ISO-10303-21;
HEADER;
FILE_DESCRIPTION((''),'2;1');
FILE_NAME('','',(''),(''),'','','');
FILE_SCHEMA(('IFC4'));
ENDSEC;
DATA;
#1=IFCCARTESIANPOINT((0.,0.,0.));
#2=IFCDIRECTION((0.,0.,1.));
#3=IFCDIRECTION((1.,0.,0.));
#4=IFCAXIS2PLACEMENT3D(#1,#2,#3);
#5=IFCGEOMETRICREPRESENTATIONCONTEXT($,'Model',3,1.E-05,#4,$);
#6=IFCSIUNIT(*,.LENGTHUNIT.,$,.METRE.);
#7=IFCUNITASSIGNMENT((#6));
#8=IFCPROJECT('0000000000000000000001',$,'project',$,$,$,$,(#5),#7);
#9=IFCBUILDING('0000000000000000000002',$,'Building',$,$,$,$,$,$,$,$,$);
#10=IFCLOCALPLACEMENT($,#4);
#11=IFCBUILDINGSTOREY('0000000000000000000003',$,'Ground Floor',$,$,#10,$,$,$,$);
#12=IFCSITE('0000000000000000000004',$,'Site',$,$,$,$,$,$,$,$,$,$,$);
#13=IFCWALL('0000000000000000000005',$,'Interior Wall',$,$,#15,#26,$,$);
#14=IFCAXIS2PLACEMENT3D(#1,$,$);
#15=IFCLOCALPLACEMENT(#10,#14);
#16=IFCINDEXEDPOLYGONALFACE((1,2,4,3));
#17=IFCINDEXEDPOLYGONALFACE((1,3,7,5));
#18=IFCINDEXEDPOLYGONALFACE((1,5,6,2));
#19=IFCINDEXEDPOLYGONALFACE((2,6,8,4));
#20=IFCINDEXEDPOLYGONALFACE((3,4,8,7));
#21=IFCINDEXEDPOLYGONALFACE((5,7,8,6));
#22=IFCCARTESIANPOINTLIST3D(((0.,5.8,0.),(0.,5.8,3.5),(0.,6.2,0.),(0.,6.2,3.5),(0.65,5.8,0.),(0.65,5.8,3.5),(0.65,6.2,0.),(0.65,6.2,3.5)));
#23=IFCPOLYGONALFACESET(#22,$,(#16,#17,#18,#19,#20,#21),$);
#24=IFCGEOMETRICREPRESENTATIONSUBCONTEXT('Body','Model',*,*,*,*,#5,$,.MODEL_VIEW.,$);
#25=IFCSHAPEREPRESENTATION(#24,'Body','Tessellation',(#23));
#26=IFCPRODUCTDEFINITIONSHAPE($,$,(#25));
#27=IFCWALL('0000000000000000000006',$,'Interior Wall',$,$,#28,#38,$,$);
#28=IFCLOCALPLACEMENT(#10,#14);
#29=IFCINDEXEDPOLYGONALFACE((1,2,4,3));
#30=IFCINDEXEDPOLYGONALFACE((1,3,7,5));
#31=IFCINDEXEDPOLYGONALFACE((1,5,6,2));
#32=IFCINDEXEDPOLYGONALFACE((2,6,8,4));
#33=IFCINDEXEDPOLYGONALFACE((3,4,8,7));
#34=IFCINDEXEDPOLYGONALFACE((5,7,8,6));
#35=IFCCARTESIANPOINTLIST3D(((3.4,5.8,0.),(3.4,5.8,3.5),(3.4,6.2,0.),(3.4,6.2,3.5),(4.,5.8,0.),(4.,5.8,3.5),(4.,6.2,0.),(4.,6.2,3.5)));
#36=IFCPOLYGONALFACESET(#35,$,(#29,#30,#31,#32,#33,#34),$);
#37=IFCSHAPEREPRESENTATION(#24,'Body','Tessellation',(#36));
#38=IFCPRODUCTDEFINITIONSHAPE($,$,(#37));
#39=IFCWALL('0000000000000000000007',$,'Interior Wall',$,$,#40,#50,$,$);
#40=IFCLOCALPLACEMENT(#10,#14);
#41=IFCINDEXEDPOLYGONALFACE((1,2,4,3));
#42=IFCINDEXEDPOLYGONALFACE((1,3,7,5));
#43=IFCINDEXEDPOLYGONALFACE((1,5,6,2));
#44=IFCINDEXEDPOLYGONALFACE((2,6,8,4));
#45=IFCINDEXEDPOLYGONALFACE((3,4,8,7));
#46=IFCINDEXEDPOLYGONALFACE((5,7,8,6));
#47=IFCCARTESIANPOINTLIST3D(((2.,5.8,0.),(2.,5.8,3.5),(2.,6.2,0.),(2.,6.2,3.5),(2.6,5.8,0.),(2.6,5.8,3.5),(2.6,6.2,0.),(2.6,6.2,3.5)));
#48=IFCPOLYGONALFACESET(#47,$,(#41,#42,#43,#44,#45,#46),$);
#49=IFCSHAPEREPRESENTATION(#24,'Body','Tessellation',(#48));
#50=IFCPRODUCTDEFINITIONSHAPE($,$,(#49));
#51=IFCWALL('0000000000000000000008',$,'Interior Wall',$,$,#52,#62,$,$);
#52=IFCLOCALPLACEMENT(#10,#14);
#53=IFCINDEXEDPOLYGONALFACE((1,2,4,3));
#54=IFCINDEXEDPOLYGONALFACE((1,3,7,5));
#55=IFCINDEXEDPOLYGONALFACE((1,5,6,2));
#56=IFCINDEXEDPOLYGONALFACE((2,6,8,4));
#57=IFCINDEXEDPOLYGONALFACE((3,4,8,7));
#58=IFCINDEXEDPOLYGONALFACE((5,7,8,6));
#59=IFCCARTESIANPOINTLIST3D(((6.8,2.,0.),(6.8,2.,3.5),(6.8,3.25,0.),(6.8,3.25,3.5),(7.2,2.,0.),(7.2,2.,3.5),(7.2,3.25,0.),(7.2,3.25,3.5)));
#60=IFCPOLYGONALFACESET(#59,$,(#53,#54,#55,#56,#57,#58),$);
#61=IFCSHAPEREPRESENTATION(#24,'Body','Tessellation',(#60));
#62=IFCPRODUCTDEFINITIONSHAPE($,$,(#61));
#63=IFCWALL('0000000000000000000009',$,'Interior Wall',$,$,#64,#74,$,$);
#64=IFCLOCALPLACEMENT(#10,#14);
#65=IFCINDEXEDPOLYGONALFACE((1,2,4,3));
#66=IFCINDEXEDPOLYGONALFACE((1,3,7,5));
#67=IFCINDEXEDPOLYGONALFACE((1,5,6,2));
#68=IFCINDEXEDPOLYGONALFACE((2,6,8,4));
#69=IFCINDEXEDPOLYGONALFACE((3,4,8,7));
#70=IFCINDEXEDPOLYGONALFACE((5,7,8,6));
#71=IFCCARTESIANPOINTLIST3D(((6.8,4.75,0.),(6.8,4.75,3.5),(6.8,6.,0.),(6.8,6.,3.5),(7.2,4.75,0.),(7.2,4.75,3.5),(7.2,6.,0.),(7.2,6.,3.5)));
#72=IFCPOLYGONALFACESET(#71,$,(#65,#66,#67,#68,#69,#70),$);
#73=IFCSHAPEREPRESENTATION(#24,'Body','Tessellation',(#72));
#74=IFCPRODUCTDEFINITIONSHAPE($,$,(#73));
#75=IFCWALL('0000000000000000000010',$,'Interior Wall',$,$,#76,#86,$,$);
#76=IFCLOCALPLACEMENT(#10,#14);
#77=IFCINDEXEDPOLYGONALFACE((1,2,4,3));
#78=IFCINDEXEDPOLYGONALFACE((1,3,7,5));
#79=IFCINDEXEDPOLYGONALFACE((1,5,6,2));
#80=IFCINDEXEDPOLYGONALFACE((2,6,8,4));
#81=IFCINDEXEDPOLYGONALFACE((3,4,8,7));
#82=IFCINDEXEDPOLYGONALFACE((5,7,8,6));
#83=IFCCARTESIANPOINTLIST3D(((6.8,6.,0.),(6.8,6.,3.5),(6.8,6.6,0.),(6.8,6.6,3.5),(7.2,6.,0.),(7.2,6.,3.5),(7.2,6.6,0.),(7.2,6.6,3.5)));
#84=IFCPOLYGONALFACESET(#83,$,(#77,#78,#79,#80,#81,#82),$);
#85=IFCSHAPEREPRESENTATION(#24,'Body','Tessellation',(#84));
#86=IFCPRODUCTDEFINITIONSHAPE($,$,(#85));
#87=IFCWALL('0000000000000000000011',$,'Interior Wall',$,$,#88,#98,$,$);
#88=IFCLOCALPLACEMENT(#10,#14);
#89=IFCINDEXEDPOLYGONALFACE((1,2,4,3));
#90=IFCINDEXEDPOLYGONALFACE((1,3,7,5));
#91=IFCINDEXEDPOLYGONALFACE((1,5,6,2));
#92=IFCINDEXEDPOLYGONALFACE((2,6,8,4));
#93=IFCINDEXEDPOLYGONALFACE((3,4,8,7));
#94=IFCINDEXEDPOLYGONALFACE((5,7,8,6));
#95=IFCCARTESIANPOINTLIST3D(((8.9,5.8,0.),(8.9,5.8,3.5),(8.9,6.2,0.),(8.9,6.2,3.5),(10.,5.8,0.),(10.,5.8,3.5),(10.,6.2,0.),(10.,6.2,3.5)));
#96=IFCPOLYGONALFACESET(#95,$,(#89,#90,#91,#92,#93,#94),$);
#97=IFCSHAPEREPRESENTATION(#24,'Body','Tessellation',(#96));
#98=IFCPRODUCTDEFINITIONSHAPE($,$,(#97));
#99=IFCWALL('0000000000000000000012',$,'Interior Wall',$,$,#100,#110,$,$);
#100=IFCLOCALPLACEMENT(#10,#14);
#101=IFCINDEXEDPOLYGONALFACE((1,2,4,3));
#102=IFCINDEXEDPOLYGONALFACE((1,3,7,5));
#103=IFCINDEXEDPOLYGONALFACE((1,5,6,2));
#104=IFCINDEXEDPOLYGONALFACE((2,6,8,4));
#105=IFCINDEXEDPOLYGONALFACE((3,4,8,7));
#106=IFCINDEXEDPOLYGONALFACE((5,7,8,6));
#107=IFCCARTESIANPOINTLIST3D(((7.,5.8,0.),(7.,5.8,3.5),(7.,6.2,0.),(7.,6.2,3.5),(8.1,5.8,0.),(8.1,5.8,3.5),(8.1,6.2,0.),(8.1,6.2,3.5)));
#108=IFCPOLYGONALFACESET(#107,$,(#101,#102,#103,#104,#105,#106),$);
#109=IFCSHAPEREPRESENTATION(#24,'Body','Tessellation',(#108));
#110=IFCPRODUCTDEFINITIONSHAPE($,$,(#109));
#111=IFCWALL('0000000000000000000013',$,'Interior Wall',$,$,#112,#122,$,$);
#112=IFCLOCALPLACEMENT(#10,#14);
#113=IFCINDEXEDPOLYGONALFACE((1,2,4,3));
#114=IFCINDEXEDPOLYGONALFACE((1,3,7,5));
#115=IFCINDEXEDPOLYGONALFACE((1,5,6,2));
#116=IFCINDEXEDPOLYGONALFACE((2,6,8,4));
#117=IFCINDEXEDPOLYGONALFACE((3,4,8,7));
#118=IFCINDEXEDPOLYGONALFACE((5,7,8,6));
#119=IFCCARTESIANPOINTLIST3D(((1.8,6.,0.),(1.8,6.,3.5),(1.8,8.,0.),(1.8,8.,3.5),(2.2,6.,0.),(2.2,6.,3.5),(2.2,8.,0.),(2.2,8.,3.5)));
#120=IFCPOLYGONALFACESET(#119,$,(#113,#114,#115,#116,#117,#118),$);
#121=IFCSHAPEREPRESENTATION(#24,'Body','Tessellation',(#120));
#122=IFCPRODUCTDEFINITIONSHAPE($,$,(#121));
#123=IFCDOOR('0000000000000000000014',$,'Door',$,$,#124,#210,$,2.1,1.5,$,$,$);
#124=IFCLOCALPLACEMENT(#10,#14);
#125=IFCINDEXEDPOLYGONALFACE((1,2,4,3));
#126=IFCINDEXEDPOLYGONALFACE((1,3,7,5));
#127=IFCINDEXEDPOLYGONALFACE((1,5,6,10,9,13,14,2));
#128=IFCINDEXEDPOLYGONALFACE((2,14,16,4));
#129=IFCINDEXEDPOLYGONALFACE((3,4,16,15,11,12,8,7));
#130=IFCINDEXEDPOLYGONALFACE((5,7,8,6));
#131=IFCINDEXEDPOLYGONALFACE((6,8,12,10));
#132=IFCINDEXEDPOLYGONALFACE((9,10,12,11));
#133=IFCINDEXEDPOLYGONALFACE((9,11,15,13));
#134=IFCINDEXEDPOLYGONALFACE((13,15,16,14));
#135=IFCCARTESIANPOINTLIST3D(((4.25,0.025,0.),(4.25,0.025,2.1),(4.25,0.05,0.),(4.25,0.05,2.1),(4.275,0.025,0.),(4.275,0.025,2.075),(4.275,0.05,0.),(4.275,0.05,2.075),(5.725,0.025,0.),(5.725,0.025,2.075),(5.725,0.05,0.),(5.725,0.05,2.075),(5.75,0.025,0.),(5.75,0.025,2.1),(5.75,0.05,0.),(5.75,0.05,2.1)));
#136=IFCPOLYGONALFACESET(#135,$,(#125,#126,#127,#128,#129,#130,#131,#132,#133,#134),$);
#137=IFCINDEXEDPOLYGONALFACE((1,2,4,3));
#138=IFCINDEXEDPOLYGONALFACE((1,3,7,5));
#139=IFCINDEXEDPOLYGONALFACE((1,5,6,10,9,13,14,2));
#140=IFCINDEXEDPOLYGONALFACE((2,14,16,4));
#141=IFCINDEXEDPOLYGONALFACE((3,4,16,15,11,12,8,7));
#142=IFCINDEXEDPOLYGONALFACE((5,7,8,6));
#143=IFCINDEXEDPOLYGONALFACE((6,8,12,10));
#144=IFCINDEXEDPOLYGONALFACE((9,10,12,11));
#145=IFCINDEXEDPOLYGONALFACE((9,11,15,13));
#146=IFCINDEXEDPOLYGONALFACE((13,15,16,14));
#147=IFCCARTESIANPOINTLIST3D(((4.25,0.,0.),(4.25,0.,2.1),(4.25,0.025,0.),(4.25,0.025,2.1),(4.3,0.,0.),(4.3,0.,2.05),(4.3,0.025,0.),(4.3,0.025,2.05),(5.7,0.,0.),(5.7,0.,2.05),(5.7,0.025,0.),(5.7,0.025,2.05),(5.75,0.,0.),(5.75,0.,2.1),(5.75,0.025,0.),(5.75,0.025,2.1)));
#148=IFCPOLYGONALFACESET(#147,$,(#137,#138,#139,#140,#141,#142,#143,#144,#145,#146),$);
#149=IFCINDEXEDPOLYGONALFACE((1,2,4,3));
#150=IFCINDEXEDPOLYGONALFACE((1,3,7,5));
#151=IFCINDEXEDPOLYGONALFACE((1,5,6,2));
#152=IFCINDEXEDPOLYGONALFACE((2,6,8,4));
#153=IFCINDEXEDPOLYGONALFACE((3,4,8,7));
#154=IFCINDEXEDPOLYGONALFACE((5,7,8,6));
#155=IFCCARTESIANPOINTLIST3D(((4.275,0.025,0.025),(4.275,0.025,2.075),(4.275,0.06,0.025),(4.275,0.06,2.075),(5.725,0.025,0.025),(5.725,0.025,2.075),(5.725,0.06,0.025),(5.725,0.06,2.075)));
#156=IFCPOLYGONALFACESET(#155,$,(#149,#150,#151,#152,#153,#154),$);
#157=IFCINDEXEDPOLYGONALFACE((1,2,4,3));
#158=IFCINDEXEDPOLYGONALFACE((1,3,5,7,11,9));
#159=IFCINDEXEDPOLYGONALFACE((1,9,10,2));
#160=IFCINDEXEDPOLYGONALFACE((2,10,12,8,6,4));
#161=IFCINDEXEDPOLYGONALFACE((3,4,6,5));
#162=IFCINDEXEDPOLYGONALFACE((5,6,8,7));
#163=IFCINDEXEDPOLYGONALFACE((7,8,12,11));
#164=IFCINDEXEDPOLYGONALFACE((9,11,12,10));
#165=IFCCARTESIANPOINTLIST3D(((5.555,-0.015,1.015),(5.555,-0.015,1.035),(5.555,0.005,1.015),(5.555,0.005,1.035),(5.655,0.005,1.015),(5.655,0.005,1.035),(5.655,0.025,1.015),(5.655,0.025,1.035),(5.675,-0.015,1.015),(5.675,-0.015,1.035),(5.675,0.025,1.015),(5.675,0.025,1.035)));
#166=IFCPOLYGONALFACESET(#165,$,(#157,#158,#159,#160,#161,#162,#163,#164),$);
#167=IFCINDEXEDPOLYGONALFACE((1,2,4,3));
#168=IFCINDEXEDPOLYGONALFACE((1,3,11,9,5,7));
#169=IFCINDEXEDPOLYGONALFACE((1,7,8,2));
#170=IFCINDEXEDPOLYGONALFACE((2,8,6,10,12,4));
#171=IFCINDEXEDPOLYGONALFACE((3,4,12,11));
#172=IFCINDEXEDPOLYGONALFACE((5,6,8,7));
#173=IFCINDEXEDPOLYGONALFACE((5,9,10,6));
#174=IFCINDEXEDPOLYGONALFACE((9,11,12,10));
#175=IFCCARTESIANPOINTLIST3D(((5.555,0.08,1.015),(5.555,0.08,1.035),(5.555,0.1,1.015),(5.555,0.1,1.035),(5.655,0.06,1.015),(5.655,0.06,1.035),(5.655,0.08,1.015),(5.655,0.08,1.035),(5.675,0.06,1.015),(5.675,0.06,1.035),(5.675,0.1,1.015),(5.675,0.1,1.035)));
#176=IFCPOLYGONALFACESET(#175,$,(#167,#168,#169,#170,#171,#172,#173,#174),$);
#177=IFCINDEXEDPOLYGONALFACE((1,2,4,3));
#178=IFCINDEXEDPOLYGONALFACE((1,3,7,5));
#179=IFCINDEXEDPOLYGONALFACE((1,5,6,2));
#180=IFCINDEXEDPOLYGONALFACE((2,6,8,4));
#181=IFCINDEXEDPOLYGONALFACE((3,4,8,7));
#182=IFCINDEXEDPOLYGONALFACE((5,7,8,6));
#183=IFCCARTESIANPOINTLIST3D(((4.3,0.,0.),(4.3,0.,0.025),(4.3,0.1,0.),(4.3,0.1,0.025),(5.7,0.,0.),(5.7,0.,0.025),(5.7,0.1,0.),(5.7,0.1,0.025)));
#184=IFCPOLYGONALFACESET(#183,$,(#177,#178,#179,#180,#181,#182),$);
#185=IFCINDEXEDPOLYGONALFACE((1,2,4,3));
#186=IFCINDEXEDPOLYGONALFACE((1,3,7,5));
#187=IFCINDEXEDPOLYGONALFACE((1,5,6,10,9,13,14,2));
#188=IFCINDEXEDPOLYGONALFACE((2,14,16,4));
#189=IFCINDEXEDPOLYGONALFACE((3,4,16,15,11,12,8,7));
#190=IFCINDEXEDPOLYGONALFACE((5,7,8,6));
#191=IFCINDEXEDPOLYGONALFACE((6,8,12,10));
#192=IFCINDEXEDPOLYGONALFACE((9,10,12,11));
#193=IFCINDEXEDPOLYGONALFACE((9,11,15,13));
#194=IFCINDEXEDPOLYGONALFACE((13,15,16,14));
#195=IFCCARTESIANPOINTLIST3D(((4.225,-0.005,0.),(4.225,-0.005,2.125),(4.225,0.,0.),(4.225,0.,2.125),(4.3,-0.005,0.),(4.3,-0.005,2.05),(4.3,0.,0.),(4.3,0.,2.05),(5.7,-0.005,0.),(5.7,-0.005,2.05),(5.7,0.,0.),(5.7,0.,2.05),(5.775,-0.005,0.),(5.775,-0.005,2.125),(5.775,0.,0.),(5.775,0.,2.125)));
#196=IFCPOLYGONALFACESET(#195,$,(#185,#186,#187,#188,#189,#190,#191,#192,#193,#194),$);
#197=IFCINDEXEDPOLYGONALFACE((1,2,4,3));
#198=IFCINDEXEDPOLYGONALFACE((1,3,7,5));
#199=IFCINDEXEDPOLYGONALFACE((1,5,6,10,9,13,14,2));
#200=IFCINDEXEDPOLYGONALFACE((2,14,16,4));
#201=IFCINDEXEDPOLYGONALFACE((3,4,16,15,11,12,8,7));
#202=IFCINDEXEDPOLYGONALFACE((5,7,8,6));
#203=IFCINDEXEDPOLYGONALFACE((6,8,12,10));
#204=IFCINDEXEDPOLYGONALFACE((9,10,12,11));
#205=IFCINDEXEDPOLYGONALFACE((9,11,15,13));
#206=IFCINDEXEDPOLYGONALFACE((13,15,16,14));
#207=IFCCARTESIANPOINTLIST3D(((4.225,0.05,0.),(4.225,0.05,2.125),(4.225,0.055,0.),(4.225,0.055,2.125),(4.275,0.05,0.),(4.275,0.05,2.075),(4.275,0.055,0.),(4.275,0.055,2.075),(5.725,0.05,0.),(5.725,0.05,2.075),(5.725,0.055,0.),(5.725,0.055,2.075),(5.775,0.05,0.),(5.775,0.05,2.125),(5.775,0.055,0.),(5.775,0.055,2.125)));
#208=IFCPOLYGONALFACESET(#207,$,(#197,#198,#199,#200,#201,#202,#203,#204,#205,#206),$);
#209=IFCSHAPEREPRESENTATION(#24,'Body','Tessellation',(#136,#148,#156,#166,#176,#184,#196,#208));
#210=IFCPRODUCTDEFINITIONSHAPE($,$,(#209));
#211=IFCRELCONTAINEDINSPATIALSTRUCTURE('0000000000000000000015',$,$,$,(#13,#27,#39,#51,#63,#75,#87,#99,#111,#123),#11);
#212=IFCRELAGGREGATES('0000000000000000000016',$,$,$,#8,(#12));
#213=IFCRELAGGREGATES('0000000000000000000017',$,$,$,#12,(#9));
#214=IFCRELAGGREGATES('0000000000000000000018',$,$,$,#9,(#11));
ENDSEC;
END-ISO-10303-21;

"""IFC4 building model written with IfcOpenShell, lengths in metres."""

from ifc_helpers import new_model, si_unit, frame, origin_with_axes, place, context, subcontext, project, spatial, line, indexed_curve, outline, extrude, element, save


model = new_model("IFC4")

# Units and contexts
model_context = context("Model", 3, precision=1e-05, world=origin_with_axes())
body_context = subcontext(model_context, "Body", "Model", "MODEL_VIEW")
ifc_project = project(units=[si_unit("LENGTHUNIT", "METRE")], contexts=[model_context])

# Site, building, storey
site = spatial("IfcSite", under=ifc_project, Name="Site")
building = spatial("IfcBuilding", under=site, Name="Building")
storey_placement = place(None, origin_with_axes())
storey = spatial("IfcBuildingStorey", under=building, at=storey_placement, Name="Ground Floor")

# Walls
for number, where, z_axis, x_axis, name in (
    (1, (0.65, 6.0, 0.0), (0.0, 0.0, 1.0), (-1.0, 0.0, 0.0), "Interior Wall"),
):
    element("IfcWall", number, at=place(storey_placement, frame(where, z_axis=z_axis, x_axis=x_axis)), inside=storey, Name=name, context=body_context, shape_type="SweptSolid", body=[
        extrude(outline(indexed_curve([(0.0, 0.0), (0.0, 0.4), (0.65, 0.4), (0.65, 0.0), (0.0, 0.0)], self_intersect=False)), frame((0.0, -0.2, 0.0), z_axis=(0.0, 0.0, 1.0), x_axis=(1.0, 0.0, 0.0)), (0.0, 0.0, 1.0), 3.5),
    ])
for number, where, z_axis, x_axis, name in (
    (2, (4.0, 6.0, 0.0), (0.0, 0.0, 1.0), (-1.0, 0.0, 0.0), "Interior Wall"),
    (3, (2.6, 6.0, 0.0), (0.0, 0.0, 1.0), (-1.0, 0.0, 0.0), "Interior Wall"),
):
    element("IfcWall", number, at=place(storey_placement, frame(where, z_axis=z_axis, x_axis=x_axis)), inside=storey, Name=name, context=body_context, shape_type="SweptSolid", body=[
        extrude(outline(indexed_curve([(0.0, 0.0), (0.0, 0.4), (0.6, 0.4), (0.6, 0.0), (0.0, 0.0)], self_intersect=False)), frame((0.0, -0.2, 0.0), z_axis=(0.0, 0.0, 1.0), x_axis=(1.0, 0.0, 0.0)), (0.0, 0.0, 1.0), 3.5),
    ])
for number, where, z_axis, x_axis, name in (
    (4, (7.0, 2.0, 0.0), (0.0, 0.0, 1.0), (0.0, 1.0, 0.0), "Interior Wall"),
    (5, (7.0, 4.75, 0.0), (0.0, 0.0, 1.0), (0.0, 1.0, 0.0), "Interior Wall"),
):
    element("IfcWall", number, at=place(storey_placement, frame(where, z_axis=z_axis, x_axis=x_axis)), inside=storey, Name=name, context=body_context, shape_type="SweptSolid", body=[
        extrude(outline(indexed_curve([(0.0, 0.0), (0.0, 0.4), (1.25, 0.4), (1.25, 0.0), (0.0, 0.0)], self_intersect=False)), frame((0.0, -0.2, 0.0), z_axis=(0.0, 0.0, 1.0), x_axis=(1.0, 0.0, 0.0)), (0.0, 0.0, 1.0), 3.5),
    ])
wall_1_placement = place(storey_placement, frame((7.0, 6.0, 0.0), z_axis=(0.0, 0.0, 1.0), x_axis=(0.0, 1.0, 0.0)))
element("IfcWall", 6, at=wall_1_placement, inside=storey, Name="Interior Wall", context=body_context, shape_type="SweptSolid", body=[
    extrude(outline(indexed_curve([(0.0, 0.0), (0.0, 0.4), (0.6, 0.4), (0.6, 0.0), (0.0, 0.0)], self_intersect=False)), frame((0.0, -0.2, 0.0), z_axis=(0.0, 0.0, 1.0), x_axis=(1.0, 0.0, 0.0)), (0.0, 0.0, 1.0), 3.5),
])
for number, where, z_axis, x_axis, name in (
    (7, (10.0, 6.0, 0.0), (0.0, 0.0, 1.0), (-1.0, 0.0, 0.0), "Interior Wall"),
    (8, (8.1, 6.0, 0.0), (0.0, 0.0, 1.0), (-1.0, 0.0, 0.0), "Interior Wall"),
):
    element("IfcWall", number, at=place(storey_placement, frame(where, z_axis=z_axis, x_axis=x_axis)), inside=storey, Name=name, context=body_context, shape_type="SweptSolid", body=[
        extrude(outline(indexed_curve([(0.0, 0.0), (0.0, 0.4), (1.1, 0.4), (1.1, 0.0), (0.0, 0.0)], self_intersect=False)), frame((0.0, -0.2, 0.0), z_axis=(0.0, 0.0, 1.0), x_axis=(1.0, 0.0, 0.0)), (0.0, 0.0, 1.0), 3.5),
    ])
wall_2_placement = place(storey_placement, frame((2.0, 6.0, 0.0), z_axis=(0.0, 0.0, 1.0), x_axis=(0.0, 1.0, 0.0)))
element("IfcWall", 9, at=wall_2_placement, inside=storey, Name="Interior Wall", context=body_context, shape_type="SweptSolid", body=[
    extrude(outline(indexed_curve([(0.0, 0.0), (0.0, 0.4), (2.0, 0.4), (2.0, 0.0), (0.0, 0.0)], self_intersect=False)), frame((0.0, -0.2, 0.0), z_axis=(0.0, 0.0, 1.0), x_axis=(1.0, 0.0, 0.0)), (0.0, 0.0, 1.0), 3.5),
])

# Door
door_1_placement = place(storey_placement, frame((4.25, 0.0, 0.0), z_axis=(0.0, 0.0, 1.0), x_axis=(1.0, 0.0, 0.0)))
element("IfcDoor", 10, at=door_1_placement, inside=storey, Name="Door", OverallHeight=2.1, OverallWidth=1.5, context=body_context, shape_type="SweptSolid", body=[
    extrude(outline(indexed_curve([(0.0, 0.0), (0.0, 2.1), (1.5, 2.1), (1.5, 0.0), (1.475, 0.0), (1.475, 2.075), (0.025, 2.075), (0.025, 0.0)], segments=[line(1, 2, 3, 4, 5, 6, 7, 8, 1)])), frame((0.0, 0.025, 0.0), z_axis=(0.0, -1.0, 0.0), x_axis=(1.0, 0.0, 0.0)), (0.0, 0.0, -1.0), 0.025),
    extrude(outline(indexed_curve([(0.0, 0.0), (0.0, 2.1), (1.5, 2.1), (1.5, 0.0), (1.45, 0.0), (1.45, 2.05), (0.05, 2.05), (0.05, 0.0)], segments=[line(1, 2, 3, 4, 5, 6, 7, 8, 1)])), frame((0.0, 0.0, 0.0), z_axis=(0.0, -1.0, 0.0), x_axis=(1.0, 0.0, 0.0)), (0.0, 0.0, -1.0), 0.025),
    extrude(outline(indexed_curve([(0.0, 0.0), (1.45, 0.0), (1.45, 0.035), (0.0, 0.035)], segments=[line(1, 2, 3, 4, 1)])), frame((0.025, 0.025, 0.025), z_axis=(0.0, 0.0, 1.0), x_axis=(1.0, 0.0, 0.0)), (0.0, 0.0, 1.0), 2.05),
    extrude(outline(indexed_curve([(0.0, 0.0), (0.0, -0.04), (-0.12, -0.04), (-0.12, -0.02), (-0.02, -0.02), (-0.02, 0.0)], segments=[line(1, 2, 3, 4, 5, 6, 1)])), frame((1.425, 0.025, 1.015), z_axis=(0.0, 0.0, 1.0), x_axis=(1.0, 0.0, 0.0)), (0.0, 0.0, 1.0), 0.02),
    extrude(outline(indexed_curve([(0.0, 0.0), (0.0, 0.04), (-0.12, 0.04), (-0.12, 0.02), (-0.02, 0.02), (-0.02, 0.0)], segments=[line(1, 2, 3, 4, 5, 6, 1)])), frame((1.425, 0.06, 1.015), z_axis=(0.0, 0.0, 1.0), x_axis=(1.0, 0.0, 0.0)), (0.0, 0.0, 1.0), 0.02),
    extrude(outline(indexed_curve([(0.0, 0.0), (1.4, 0.0), (1.4, 0.1), (0.0, 0.1)], segments=[line(1, 2, 3, 4, 1)])), frame((0.05, 0.0, 0.0), z_axis=(0.0, 0.0, 1.0), x_axis=(1.0, 0.0, 0.0)), (0.0, 0.0, 1.0), 0.025),
    extrude(outline(indexed_curve([(0.0, 0.0), (0.0, 2.125), (1.55, 2.125), (1.55, 0.0), (1.475, 0.0), (1.475, 2.05), (0.075, 2.05), (0.075, 0.0)], segments=[line(1, 2, 3, 4, 5, 6, 7, 8, 1)])), frame((-0.025, -0.005, 0.0), z_axis=(0.0, -1.0, 0.0), x_axis=(1.0, 0.0, 0.0)), (0.0, 0.0, -1.0), 0.005),
    extrude(outline(indexed_curve([(0.0, 0.0), (0.0, 2.125), (1.55, 2.125), (1.55, 0.0), (1.5, 0.0), (1.5, 2.075), (0.05, 2.075), (0.05, 0.0)], segments=[line(1, 2, 3, 4, 5, 6, 7, 8, 1)])), frame((-0.025, 0.05, 0.0), z_axis=(0.0, -1.0, 0.0), x_axis=(1.0, 0.0, 0.0)), (0.0, 0.0, -1.0), 0.005),
])

save(model, "model.ifc")
